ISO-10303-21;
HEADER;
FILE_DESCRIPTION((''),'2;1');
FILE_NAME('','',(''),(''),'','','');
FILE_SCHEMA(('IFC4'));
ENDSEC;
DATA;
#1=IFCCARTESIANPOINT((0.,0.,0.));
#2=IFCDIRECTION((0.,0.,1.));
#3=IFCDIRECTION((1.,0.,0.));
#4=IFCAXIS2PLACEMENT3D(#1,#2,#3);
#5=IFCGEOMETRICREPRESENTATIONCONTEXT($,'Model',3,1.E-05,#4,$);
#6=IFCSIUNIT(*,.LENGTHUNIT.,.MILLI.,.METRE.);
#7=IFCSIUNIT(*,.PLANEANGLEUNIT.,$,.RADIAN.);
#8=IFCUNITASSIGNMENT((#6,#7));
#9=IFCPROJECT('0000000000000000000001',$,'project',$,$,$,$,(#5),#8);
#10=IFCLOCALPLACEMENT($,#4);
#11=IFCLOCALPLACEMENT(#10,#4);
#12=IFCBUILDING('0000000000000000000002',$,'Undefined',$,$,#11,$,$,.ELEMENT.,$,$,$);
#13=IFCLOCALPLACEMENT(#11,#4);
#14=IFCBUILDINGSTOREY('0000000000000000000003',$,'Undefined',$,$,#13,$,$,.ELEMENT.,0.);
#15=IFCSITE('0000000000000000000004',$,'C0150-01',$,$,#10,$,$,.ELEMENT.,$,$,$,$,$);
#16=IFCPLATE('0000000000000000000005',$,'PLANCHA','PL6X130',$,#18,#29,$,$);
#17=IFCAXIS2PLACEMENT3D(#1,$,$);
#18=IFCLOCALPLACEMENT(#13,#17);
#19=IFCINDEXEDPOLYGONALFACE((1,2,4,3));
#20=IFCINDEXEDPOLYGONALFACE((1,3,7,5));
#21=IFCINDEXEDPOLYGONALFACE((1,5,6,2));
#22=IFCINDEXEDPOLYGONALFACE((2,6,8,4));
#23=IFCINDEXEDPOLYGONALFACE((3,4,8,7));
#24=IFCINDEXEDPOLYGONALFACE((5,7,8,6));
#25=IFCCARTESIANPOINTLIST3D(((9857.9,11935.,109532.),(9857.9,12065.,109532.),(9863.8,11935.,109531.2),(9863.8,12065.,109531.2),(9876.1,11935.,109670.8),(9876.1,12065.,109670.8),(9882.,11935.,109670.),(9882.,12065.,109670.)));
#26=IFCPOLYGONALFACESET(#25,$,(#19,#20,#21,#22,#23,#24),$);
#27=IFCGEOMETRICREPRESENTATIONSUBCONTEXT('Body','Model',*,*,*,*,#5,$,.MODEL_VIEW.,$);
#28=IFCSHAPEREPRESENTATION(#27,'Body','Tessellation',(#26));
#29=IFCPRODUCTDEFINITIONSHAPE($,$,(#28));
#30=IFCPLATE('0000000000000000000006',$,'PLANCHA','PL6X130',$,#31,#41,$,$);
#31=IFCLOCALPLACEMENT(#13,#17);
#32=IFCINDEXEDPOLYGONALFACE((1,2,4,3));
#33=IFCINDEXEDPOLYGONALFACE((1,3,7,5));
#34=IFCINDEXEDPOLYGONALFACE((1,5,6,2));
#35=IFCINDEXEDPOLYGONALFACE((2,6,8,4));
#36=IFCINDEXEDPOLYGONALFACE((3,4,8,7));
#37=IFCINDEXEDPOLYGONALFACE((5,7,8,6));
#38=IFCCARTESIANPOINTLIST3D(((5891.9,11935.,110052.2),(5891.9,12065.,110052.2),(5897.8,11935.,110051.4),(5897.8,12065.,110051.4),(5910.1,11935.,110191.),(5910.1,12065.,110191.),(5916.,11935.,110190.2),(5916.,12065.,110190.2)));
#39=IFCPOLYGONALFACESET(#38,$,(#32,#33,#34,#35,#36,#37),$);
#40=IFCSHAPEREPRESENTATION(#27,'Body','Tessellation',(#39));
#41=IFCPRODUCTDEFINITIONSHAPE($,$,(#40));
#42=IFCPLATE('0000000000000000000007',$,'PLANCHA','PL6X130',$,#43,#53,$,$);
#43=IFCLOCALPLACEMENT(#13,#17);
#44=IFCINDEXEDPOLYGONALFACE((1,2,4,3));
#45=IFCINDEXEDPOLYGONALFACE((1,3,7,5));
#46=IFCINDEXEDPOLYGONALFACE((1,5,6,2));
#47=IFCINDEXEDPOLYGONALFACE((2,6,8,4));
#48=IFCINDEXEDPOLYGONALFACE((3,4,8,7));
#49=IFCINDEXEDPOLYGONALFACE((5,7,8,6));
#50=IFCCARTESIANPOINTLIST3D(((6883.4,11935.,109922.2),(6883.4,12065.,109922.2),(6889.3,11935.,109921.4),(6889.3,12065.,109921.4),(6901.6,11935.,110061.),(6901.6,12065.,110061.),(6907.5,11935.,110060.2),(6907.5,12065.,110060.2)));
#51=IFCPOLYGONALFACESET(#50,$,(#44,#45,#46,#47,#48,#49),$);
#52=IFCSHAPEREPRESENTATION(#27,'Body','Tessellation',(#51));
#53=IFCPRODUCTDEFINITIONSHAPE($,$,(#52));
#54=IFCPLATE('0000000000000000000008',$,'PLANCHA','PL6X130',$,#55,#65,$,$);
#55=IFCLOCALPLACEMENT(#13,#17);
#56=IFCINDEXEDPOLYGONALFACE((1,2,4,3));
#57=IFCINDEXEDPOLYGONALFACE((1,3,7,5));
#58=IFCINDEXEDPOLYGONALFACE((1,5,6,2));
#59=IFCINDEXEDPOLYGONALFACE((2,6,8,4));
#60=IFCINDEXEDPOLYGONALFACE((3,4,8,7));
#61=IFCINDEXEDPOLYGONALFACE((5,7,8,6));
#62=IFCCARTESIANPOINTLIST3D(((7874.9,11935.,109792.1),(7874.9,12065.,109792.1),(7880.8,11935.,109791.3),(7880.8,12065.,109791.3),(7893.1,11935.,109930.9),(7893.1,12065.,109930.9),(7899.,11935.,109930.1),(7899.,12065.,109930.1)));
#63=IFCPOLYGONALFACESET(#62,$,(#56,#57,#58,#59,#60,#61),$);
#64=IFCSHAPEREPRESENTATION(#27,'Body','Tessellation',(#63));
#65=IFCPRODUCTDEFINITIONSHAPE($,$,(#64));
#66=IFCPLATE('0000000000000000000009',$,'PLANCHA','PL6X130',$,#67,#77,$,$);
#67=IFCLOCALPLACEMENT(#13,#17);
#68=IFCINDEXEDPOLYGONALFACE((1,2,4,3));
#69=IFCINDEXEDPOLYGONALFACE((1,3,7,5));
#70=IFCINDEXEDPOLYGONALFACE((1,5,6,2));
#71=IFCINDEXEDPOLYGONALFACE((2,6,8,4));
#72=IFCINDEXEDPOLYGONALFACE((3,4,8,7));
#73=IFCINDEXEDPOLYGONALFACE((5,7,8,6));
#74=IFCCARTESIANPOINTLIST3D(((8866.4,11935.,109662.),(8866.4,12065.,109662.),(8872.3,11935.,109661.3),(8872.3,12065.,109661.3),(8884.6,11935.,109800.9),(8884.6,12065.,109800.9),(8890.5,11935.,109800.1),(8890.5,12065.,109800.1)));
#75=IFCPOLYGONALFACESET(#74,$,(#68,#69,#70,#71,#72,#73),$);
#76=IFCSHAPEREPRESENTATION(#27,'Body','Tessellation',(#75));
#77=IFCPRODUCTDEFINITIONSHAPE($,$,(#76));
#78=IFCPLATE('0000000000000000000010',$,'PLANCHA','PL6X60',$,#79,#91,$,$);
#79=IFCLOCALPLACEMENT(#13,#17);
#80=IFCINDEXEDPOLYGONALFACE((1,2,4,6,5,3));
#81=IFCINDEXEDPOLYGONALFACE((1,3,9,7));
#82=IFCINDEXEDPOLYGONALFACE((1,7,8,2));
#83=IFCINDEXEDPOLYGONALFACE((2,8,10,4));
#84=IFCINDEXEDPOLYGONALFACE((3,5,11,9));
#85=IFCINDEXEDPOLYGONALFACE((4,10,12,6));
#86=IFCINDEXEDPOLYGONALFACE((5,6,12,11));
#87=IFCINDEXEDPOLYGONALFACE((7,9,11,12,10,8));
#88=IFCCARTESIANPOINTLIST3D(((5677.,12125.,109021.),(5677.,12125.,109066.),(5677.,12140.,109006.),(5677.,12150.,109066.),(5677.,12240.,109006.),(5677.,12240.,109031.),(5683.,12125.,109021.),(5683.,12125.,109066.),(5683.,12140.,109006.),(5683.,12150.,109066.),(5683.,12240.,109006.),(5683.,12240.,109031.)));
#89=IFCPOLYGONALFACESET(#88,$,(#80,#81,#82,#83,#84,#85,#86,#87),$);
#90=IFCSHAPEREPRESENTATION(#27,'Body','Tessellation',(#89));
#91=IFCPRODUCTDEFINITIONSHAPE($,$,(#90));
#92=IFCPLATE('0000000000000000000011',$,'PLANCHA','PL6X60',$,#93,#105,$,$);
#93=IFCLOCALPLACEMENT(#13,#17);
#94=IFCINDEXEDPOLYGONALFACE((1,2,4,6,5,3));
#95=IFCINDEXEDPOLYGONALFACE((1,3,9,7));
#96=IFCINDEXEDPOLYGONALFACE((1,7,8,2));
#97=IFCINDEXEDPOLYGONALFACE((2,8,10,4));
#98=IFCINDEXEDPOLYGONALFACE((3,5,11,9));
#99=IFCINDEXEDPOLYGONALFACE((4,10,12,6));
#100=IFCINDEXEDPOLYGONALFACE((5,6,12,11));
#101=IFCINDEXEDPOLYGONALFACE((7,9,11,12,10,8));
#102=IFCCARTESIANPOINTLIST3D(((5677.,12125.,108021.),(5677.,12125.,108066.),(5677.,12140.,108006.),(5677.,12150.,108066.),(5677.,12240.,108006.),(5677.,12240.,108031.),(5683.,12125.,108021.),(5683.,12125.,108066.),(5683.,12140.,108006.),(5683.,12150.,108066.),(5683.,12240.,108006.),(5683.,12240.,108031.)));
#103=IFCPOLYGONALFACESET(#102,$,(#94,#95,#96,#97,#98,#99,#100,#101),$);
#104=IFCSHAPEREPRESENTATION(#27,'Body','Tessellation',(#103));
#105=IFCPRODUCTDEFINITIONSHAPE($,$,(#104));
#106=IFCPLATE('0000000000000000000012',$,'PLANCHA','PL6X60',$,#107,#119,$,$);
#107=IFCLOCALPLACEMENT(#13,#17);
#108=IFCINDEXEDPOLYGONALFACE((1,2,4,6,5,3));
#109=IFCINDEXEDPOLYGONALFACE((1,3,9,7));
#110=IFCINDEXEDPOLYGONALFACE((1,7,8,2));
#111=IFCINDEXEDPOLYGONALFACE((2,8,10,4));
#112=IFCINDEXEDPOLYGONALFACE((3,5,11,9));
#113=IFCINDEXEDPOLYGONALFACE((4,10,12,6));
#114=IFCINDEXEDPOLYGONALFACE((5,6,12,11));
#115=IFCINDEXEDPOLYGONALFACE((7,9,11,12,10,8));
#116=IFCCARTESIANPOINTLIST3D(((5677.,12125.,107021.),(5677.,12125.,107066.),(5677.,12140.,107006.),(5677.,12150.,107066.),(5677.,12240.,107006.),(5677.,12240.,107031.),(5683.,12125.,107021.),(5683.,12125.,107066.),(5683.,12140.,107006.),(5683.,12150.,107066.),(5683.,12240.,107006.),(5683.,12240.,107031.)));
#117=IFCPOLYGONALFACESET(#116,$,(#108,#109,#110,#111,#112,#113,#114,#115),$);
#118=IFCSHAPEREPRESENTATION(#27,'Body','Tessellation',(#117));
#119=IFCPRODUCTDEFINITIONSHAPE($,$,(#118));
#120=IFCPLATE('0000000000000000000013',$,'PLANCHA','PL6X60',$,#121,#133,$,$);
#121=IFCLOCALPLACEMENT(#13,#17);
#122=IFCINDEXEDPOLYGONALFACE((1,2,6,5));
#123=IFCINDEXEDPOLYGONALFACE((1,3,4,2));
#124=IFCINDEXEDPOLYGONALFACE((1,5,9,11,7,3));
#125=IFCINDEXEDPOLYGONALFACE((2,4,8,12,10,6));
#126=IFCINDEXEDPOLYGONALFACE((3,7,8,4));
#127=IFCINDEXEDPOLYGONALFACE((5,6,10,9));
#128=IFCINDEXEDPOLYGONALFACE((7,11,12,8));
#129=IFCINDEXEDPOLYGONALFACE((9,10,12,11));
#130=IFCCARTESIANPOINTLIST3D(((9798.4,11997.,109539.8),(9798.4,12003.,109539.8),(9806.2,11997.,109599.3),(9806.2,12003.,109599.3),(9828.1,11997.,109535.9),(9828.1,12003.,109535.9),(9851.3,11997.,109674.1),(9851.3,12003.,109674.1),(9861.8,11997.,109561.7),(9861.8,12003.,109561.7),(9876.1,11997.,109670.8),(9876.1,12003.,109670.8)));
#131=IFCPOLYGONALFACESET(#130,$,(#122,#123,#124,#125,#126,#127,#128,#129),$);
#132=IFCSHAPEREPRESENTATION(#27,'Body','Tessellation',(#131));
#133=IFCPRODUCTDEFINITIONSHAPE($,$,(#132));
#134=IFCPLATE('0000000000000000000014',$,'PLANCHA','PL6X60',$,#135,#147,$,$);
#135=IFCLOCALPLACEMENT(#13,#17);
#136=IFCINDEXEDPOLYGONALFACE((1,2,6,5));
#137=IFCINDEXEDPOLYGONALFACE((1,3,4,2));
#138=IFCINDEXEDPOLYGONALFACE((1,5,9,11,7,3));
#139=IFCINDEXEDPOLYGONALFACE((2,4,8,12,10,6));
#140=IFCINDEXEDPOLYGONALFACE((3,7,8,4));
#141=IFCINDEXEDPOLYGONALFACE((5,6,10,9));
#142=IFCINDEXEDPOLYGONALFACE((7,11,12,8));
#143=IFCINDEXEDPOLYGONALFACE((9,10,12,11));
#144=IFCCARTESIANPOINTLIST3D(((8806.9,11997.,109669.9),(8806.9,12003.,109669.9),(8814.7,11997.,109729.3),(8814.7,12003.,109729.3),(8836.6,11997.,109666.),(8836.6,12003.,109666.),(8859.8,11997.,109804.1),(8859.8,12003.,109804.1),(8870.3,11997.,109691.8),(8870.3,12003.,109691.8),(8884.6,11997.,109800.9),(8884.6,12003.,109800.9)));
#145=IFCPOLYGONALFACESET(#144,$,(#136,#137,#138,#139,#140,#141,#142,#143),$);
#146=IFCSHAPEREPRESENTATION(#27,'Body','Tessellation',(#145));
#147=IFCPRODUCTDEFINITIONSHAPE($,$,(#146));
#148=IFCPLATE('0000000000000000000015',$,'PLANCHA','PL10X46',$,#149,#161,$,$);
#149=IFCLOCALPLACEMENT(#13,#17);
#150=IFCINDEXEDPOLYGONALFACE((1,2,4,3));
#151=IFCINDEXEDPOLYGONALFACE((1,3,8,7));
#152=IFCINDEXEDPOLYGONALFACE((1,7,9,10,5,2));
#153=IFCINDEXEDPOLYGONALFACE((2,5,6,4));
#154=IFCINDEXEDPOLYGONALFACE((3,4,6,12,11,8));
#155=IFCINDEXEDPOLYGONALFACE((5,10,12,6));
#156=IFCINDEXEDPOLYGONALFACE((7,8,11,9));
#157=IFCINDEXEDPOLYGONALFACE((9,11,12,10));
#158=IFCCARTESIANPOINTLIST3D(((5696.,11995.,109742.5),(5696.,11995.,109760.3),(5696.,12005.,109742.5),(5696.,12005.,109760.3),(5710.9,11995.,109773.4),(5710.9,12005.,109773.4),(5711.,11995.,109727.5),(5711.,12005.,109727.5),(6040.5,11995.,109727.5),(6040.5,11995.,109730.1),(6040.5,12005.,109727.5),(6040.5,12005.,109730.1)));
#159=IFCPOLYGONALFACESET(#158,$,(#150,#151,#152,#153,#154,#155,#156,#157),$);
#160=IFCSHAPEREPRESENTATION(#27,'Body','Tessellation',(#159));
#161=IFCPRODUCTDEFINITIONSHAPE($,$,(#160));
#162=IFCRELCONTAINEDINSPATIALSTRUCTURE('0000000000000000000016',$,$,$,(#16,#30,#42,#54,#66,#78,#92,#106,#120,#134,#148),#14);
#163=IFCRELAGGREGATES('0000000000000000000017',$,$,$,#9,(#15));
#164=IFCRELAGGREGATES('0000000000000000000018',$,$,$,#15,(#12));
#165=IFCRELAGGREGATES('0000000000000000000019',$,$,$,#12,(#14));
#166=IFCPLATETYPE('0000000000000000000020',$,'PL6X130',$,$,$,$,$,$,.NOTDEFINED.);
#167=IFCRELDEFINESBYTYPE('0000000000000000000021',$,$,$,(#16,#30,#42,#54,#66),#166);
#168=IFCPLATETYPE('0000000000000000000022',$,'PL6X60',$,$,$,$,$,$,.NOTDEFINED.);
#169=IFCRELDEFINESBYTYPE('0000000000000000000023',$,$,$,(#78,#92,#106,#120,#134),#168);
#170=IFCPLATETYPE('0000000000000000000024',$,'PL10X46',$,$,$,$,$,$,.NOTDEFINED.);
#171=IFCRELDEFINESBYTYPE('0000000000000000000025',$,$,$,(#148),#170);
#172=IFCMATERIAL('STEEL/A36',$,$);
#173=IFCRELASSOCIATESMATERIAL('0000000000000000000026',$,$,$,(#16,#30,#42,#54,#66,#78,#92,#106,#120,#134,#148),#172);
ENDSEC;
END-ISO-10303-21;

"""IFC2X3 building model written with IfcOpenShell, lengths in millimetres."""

from ifc_helpers import new_model, si_unit, frame, origin_with_axes, place, context, subcontext, project, spatial, polyline, outline, extrude, material, type_object, element, save


model = new_model("IFC2X3")

# Units and contexts
model_context = context("Model", 3, precision=1e-05, world=origin_with_axes())
body_context = subcontext(model_context, "Body", "Model", "MODEL_VIEW")
ifc_project = project(units=[si_unit("LENGTHUNIT", "METRE", prefix="MILLI"), si_unit("PLANEANGLEUNIT", "RADIAN")], contexts=[model_context])

# Site, building, storey
site_placement = place(None, origin_with_axes())
site = spatial("IfcSite", under=ifc_project, at=site_placement, Name="C0150-01", CompositionType="ELEMENT")
building_placement = place(site_placement, origin_with_axes())
building = spatial("IfcBuilding", under=site, at=building_placement, Name="Undefined", CompositionType="ELEMENT")
storey_placement = place(building_placement, origin_with_axes())
storey = spatial("IfcBuildingStorey", under=building, at=storey_placement, Name="Undefined", CompositionType="ELEMENT", Elevation=0.0)

# Shared definitions
ifc_material_1 = material(Name="STEEL/A36")

# Plates
plate_type_1 = type_object("IfcPlateType", Name="PL6X130", PredefinedType="NOTDEFINED")
for number, where, z_axis, x_axis, name in (
    (1, (9860.9, 12065.0, 109531.6), (-0.991507, 0.0, 0.130054), (0.0, -1.0, 0.0), "PLANCHA"),
    (2, (5894.8, 12065.0, 110051.8), (-0.991507, 0.0, 0.130054), (0.0, -1.0, 0.0), "PLANCHA"),
    (3, (6886.3, 12065.0, 109921.8), (-0.991507, 0.0, 0.130054), (0.0, -1.0, 0.0), "PLANCHA"),
    (4, (7877.8, 12065.0, 109791.7), (-0.991507, 0.0, 0.130054), (0.0, -1.0, 0.0), "PLANCHA"),
    (5, (8869.4, 12065.0, 109661.7), (-0.991507, 0.0, 0.130054), (0.0, -1.0, 0.0), "PLANCHA"),
):
    element("IfcPlate", number, at=place(storey_placement, frame(where, z_axis=z_axis, x_axis=x_axis)), inside=storey, type_object=plate_type_1, material=ifc_material_1, Name=name, Description="PL6X130", context=body_context, shape_type="SweptSolid", body=[
        extrude(outline(polyline([(0.0, 0.0), (130.0, 0.0), (130.0, 140.0), (0.0, 140.0), (0.0, 0.0)])), frame((0.0, 0.0, -3.0), z_axis=(0.0, 0.0, 1.0), x_axis=(1.0, 0.0, 0.0)), (0.0, 0.0, 1.0), 6.0),
    ])
plate_type_2 = type_object("IfcPlateType", Name="PL6X60", PredefinedType="NOTDEFINED")
for number, where, z_axis, x_axis, name in (
    (6, (5680.0, 12240.0, 109031.0), (-1.0, 0.0, 0.0), (0.0, 0.000004, -1.0), "PLANCHA"),
    (7, (5680.0, 12240.0, 108031.0), (-1.0, 0.0, 0.0), (0.0, 0.000004, -1.0), "PLANCHA"),
    (8, (5680.0, 12240.0, 107031.0), (-1.0, 0.0, 0.0), (0.0, 0.000004, -1.0), "PLANCHA"),
):
    element("IfcPlate", number, at=place(storey_placement, frame(where, z_axis=z_axis, x_axis=x_axis)), inside=storey, type_object=plate_type_2, material=ifc_material_1, Name=name, Description="PL6X60", context=body_context, shape_type="SweptSolid", body=[
        extrude(outline(polyline([(0.0, 0.0), (25.0, 0.0), (25.0, 100.0), (10.0, 115.0), (-35.0, 115.0), (-35.0, 90.0), (0.0, 0.0)])), frame((0.0, 0.0, -3.0), z_axis=(0.0, 0.0, 1.0), x_axis=(1.0, 0.0, 0.0)), (0.0, 0.0, 1.0), 6.0),
    ])
for number, where, z_axis, x_axis, name in (
    (9, (9851.3, 12000.0, 109674.1), (0.0, 1.0, 0.0), (0.991507, 0.0, -0.130054), "PLANCHA"),
    (10, (8859.8, 12000.0, 109804.1), (0.0, 1.0, 0.0), (0.991507, 0.0, -0.130054), "PLANCHA"),
):
    element("IfcPlate", number, at=place(storey_placement, frame(where, z_axis=z_axis, x_axis=x_axis)), inside=storey, type_object=plate_type_2, material=ifc_material_1, Name=name, Description="PL6X60", context=body_context, shape_type="SweptSolid", body=[
        extrude(outline(polyline([(0.0, 0.0), (25.0, 0.0), (25.0, 110.0), (-5.0, 140.0), (-35.0, 140.0), (-35.0, 80.0), (0.0, 0.0)])), frame((0.0, 0.0, -3.0), z_axis=(0.0, 0.0, 1.0), x_axis=(1.0, 0.0, 0.0)), (0.0, 0.0, 1.0), 6.0),
    ])
plate_type_3 = type_object("IfcPlateType", Name="PL10X46", PredefinedType="NOTDEFINED")
plate_placement = place(storey_placement, frame((5696.0, 12000.0, 109727.5), z_axis=(0.0, 1.0, 0.0), x_axis=(0.0, 0.0, 1.0)))
element("IfcPlate", 11, at=plate_placement, inside=storey, type_object=plate_type_3, material=ifc_material_1, Name="PLANCHA", Description="PL10X46", context=body_context, shape_type="SweptSolid", body=[
    extrude(outline(polyline([(0.0, 15.0), (15.0, 0.0), (32.8, 0.0), (45.9, 14.9), (2.6, 344.5), (0.0, 344.5), (0.0, 15.0)])), frame((0.0, 0.0, -5.0), z_axis=(0.0, 0.0, 1.0), x_axis=(1.0, 0.0, 0.0)), (0.0, 0.0, 1.0), 10.0),
])

save(model, "model.ifc")
